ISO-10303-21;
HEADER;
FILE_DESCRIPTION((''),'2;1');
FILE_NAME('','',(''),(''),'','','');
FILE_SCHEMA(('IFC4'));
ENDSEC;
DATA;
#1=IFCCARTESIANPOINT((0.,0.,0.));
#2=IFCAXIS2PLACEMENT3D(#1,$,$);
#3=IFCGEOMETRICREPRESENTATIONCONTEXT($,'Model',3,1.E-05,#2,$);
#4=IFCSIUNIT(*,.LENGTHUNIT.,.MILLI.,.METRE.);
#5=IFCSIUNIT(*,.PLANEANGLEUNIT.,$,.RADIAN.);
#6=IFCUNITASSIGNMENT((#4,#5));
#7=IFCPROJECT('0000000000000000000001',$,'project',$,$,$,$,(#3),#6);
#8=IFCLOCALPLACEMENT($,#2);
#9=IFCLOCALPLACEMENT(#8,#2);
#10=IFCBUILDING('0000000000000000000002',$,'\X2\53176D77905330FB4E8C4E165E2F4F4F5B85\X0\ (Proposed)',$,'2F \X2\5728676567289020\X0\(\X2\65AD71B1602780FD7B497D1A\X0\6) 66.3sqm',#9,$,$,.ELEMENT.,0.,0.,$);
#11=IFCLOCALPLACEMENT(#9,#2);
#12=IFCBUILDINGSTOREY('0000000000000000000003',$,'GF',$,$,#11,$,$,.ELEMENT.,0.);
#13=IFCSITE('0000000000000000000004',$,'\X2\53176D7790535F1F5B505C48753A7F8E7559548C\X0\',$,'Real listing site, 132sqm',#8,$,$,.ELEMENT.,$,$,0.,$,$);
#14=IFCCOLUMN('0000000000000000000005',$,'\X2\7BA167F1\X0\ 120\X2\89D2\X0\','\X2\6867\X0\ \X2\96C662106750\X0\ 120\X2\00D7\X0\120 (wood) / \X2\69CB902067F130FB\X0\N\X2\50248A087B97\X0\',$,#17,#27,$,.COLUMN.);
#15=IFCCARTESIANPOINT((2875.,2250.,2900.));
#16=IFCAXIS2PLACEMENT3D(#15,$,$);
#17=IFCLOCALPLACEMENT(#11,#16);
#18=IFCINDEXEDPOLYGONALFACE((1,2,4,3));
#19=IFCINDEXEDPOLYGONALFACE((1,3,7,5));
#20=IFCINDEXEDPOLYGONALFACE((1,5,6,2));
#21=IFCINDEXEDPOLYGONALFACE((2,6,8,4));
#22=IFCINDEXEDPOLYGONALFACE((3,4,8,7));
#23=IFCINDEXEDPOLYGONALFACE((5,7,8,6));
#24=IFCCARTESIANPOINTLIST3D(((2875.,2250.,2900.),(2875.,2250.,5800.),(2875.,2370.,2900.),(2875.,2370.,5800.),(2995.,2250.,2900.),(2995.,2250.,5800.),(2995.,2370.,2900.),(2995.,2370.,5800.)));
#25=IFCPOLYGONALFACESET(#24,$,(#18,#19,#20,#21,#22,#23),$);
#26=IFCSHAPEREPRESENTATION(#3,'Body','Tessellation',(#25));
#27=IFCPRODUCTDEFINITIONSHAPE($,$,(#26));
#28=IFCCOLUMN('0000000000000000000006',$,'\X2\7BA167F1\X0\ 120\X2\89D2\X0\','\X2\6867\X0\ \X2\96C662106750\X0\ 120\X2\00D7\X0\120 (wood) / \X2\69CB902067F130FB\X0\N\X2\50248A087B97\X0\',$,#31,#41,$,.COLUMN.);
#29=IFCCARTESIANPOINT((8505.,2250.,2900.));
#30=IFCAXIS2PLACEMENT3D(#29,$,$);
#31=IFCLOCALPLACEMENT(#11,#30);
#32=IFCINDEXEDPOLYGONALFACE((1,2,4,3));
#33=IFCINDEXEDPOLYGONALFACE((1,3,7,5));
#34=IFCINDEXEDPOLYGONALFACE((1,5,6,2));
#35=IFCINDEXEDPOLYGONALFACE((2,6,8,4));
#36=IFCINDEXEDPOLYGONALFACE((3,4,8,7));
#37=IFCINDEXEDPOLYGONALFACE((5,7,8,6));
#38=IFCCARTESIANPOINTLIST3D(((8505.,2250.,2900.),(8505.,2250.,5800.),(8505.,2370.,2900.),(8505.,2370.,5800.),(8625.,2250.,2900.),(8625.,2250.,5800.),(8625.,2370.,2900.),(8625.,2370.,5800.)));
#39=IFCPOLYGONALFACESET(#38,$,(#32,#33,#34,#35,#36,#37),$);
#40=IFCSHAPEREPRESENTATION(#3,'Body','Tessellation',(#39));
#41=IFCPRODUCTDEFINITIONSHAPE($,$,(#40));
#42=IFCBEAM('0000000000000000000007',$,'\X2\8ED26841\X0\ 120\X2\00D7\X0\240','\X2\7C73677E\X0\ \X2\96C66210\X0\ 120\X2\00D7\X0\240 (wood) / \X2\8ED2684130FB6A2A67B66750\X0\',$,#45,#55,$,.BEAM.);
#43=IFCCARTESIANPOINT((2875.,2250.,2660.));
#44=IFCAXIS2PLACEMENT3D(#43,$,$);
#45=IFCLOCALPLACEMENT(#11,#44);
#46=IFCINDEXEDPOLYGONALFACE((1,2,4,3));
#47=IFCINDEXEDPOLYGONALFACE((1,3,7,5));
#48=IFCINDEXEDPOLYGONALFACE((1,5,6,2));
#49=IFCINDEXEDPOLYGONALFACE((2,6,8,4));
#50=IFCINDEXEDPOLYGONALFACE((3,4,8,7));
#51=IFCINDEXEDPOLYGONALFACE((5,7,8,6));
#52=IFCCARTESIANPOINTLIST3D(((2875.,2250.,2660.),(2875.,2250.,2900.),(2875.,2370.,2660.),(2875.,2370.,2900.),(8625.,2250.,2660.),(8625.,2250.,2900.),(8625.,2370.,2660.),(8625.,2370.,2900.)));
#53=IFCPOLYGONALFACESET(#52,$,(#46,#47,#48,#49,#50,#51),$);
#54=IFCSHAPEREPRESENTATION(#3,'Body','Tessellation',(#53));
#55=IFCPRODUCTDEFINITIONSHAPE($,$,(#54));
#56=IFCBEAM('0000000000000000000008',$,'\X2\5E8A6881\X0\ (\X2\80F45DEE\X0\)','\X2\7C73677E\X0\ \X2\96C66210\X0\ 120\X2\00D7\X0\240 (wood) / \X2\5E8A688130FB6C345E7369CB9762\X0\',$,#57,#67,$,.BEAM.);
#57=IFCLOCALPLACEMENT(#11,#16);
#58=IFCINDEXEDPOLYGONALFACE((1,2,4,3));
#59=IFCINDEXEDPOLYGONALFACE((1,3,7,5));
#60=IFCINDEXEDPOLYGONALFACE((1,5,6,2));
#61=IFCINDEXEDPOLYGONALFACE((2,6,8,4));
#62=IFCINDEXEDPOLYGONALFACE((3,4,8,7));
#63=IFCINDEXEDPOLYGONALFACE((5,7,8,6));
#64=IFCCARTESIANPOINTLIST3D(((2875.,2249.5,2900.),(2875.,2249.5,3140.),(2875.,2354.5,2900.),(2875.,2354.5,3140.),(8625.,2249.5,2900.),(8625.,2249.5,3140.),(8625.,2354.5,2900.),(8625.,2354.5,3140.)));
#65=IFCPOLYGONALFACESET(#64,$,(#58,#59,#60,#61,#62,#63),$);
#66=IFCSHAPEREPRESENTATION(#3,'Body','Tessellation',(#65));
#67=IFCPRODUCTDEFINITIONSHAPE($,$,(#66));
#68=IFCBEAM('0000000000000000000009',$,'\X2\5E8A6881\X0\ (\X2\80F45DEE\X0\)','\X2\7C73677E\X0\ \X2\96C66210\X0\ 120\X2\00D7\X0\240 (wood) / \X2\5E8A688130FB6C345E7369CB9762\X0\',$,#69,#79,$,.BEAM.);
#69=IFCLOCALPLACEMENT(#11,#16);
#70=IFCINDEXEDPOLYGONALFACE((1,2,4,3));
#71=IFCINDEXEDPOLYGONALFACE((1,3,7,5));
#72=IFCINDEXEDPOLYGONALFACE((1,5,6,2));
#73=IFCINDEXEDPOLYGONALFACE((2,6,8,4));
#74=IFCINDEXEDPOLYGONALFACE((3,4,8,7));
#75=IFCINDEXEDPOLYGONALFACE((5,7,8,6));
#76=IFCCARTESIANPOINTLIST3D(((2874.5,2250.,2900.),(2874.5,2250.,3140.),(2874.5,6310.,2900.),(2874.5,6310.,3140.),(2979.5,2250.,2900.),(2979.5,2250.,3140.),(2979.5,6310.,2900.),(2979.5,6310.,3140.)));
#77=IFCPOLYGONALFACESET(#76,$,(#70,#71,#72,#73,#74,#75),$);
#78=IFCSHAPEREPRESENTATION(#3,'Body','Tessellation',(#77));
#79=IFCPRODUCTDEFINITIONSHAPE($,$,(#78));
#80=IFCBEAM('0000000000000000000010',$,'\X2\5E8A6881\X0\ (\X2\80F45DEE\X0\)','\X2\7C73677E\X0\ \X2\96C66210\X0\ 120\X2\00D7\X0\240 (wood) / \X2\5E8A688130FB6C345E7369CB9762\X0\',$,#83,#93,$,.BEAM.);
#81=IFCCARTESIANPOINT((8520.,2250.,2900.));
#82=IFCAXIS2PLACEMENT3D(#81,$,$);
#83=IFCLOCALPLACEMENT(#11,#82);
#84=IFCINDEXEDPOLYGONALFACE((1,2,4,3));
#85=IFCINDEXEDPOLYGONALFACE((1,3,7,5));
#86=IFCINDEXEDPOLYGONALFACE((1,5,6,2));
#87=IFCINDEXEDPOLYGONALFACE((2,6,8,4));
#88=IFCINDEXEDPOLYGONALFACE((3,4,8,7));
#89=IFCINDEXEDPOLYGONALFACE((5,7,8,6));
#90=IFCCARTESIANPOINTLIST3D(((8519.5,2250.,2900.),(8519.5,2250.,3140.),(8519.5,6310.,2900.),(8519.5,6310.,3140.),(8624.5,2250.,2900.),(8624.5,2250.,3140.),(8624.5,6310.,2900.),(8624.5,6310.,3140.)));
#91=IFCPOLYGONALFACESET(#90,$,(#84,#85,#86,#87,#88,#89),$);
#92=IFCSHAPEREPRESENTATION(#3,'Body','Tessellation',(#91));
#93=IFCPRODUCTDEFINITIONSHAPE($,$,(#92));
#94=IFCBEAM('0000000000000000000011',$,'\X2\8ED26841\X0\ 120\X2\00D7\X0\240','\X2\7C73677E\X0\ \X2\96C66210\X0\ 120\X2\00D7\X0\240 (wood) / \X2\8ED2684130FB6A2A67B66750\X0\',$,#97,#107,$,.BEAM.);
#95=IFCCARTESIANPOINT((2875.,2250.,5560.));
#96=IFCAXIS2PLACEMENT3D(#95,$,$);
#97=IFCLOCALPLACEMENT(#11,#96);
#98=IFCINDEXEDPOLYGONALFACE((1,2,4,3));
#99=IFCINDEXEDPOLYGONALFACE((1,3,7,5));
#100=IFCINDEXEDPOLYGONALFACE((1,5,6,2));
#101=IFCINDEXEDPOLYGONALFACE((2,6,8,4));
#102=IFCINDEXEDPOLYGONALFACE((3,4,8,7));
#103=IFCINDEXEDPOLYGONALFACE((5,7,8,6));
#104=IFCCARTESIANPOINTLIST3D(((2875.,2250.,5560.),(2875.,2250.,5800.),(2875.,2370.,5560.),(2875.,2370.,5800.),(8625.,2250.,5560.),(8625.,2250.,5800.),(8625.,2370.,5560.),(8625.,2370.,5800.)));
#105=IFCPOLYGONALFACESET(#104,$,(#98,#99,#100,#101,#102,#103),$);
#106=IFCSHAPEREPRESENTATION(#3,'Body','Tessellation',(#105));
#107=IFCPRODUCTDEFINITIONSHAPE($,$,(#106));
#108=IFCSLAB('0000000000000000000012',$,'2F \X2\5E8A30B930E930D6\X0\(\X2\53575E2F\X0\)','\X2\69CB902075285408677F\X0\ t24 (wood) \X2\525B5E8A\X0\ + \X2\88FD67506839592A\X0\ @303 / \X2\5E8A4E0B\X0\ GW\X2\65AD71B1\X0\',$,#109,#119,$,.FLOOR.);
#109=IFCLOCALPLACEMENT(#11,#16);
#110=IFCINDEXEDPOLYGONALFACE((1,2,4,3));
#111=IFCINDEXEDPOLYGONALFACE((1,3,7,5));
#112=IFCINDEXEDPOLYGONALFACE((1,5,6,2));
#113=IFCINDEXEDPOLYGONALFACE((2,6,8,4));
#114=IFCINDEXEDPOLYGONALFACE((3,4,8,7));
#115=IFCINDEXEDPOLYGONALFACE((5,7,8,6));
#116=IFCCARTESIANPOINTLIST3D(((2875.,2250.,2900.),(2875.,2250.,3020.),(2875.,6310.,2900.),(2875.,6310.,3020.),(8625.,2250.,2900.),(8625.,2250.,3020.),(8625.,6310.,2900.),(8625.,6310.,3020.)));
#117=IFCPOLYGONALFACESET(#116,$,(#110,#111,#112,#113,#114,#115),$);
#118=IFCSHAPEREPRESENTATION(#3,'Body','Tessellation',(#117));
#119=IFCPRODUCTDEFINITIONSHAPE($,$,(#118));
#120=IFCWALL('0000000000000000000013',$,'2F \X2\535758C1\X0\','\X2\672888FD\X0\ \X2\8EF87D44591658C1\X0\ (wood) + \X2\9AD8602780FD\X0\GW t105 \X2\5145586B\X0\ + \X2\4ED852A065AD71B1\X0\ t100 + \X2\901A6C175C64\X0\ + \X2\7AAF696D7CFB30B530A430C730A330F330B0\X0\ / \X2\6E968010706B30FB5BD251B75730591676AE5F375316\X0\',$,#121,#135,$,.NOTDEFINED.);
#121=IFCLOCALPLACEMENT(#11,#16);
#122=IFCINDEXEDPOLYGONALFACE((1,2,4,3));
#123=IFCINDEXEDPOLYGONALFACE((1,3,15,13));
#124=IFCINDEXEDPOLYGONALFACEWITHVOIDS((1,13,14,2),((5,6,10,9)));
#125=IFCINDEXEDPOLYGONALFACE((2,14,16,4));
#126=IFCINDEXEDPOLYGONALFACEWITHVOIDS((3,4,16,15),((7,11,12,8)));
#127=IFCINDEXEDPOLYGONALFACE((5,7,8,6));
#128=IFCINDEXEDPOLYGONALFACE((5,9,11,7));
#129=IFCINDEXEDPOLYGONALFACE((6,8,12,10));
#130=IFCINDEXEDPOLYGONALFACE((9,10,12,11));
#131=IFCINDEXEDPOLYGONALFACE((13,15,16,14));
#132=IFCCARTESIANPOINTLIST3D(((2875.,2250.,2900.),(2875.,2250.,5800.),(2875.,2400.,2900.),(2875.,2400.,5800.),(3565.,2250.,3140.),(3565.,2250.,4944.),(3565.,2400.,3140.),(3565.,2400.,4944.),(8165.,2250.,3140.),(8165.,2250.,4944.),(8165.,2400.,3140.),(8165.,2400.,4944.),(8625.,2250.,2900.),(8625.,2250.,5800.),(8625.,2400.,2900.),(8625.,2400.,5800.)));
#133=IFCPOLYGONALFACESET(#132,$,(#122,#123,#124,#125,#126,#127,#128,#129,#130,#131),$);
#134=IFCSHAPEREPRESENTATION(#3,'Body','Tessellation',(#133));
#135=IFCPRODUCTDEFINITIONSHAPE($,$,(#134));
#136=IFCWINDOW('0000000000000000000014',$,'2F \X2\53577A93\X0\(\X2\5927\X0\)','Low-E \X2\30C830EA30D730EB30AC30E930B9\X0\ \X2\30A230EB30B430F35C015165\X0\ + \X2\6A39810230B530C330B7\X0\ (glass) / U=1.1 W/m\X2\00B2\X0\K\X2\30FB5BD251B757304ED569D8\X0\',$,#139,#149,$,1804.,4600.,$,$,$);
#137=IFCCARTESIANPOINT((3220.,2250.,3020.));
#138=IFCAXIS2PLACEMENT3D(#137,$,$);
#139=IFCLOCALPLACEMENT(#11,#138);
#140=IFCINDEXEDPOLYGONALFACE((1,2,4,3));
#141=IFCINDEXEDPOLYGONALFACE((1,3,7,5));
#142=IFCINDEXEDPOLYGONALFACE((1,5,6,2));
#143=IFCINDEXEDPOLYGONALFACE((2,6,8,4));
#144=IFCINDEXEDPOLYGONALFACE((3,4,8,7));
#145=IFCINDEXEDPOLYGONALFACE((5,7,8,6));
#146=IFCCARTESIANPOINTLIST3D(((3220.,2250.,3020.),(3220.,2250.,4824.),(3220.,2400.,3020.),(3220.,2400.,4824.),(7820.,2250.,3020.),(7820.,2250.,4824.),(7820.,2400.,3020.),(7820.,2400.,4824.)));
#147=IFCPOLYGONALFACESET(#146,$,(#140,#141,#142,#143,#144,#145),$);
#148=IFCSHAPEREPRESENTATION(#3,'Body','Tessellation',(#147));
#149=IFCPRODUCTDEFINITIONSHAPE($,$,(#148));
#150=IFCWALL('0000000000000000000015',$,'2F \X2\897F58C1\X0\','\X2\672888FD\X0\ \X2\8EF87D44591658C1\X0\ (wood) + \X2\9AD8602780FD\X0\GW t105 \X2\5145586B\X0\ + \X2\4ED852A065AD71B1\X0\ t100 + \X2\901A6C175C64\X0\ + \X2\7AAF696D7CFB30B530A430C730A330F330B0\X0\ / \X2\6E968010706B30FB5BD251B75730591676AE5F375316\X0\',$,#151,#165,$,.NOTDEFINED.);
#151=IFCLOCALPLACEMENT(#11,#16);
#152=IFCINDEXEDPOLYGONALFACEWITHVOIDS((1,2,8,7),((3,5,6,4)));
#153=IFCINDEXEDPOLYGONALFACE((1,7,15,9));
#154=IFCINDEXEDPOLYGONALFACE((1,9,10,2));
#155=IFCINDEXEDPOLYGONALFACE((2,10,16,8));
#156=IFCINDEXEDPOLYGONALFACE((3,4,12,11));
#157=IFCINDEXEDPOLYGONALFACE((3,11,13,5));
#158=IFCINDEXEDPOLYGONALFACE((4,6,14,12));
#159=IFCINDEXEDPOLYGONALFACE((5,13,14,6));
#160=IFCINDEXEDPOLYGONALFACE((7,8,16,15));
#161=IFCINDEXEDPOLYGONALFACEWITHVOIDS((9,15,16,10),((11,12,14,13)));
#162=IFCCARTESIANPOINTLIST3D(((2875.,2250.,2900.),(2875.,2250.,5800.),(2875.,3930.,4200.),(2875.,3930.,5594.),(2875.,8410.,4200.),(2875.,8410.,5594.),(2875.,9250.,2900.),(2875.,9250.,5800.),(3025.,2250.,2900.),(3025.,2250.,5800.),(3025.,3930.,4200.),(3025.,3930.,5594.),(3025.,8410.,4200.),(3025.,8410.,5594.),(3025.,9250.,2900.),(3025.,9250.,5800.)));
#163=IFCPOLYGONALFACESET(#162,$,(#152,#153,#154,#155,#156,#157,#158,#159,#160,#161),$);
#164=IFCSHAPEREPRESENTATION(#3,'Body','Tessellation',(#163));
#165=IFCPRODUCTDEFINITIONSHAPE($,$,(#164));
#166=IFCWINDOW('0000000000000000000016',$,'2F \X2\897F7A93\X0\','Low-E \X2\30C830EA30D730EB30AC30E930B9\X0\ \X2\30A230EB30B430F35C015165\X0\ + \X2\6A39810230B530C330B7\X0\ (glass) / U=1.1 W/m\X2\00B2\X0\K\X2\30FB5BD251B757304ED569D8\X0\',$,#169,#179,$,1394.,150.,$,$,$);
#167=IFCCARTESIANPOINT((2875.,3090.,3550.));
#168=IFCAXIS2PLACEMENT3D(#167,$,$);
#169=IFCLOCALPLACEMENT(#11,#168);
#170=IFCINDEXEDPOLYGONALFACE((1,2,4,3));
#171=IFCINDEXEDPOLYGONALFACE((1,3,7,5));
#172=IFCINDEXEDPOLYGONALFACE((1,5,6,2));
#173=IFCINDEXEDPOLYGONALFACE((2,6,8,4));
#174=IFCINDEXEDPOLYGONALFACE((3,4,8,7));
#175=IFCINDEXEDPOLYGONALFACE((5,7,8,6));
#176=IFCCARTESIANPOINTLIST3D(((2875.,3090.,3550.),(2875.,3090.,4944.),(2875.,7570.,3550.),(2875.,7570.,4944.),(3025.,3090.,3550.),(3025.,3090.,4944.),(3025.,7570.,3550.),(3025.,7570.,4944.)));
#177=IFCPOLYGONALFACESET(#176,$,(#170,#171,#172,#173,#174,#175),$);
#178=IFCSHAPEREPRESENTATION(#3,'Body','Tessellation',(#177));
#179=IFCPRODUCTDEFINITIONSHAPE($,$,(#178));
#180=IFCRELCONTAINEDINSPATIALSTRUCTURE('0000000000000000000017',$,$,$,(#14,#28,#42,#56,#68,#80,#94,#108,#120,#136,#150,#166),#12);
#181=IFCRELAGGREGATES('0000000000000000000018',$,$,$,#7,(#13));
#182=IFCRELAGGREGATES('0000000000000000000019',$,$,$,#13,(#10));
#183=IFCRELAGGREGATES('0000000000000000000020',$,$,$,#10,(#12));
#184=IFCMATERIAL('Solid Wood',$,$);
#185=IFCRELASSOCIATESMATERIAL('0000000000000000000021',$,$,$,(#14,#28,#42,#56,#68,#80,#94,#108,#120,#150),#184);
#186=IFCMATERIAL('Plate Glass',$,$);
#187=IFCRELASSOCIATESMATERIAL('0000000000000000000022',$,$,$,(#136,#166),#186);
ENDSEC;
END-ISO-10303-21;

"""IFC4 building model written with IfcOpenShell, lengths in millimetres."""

from ifc_helpers import new_model, si_unit, frame, frame_2d, origin, place, context, project, spatial, rectangle, extrude, material, element, fill, save


model = new_model("IFC4")

# Units and contexts
model_context = context("Model", 3, precision=1e-05, world=origin())
ifc_project = project(units=[si_unit("LENGTHUNIT", "METRE", prefix="MILLI"), si_unit("PLANEANGLEUNIT", "RADIAN")], contexts=[model_context])

# Site, building, storey
site_placement = place(None, origin())
site = spatial("IfcSite", under=ifc_project, at=site_placement, Name="北海道弟子屈町美留和", ObjectType="Real listing site, 132sqm", CompositionType="ELEMENT", RefElevation=0.0)
building_placement = place(site_placement, origin())
building = spatial("IfcBuilding", under=site, at=building_placement, Name="北海道・二世帯住宅 (Proposed)", ObjectType="2F 在来木造(断熱性能等級6) 66.3sqm", CompositionType="ELEMENT", ElevationOfRefHeight=0.0, ElevationOfTerrain=0.0)
storey_placement = place(building_placement, origin())
storey = spatial("IfcBuildingStorey", under=building, at=storey_placement, Name="GF", CompositionType="ELEMENT", Elevation=0.0)

# Columns
ifc_material_1 = material(Name="Solid Wood")
column_1_placement = place(storey_placement, frame((2875.0, 2250.0, 2900.0)))
element("IfcColumn", 1, at=column_1_placement, inside=storey, material=ifc_material_1, Name="管柱 120角", Description="桧 集成材 120×120 (wood) / 構造柱・N値計算", PredefinedType="COLUMN", context=model_context, shape_type="SweptSolid", body=[
    extrude(rectangle(XDim=120.0, YDim=120.0, at=frame_2d((60.0, 60.0))), frame((2875.0, 2250.0, 2900.0)), (0.0, 0.0, 1.0), 2900.0),
])
column_2_placement = place(storey_placement, frame((8505.0, 2250.0, 2900.0)))
element("IfcColumn", 2, at=column_2_placement, inside=storey, material=ifc_material_1, Name="管柱 120角", Description="桧 集成材 120×120 (wood) / 構造柱・N値計算", PredefinedType="COLUMN", context=model_context, shape_type="SweptSolid", body=[
    extrude(rectangle(XDim=120.0, YDim=120.0, at=frame_2d((60.0, 60.0))), frame((8505.0, 2250.0, 2900.0)), (0.0, 0.0, 1.0), 2900.0),
])

# Beams
beam_1_placement = place(storey_placement, frame((2875.0, 2250.0, 2660.0)))
element("IfcBeam", 3, at=beam_1_placement, inside=storey, material=ifc_material_1, Name="軒桁 120×240", Description="米松 集成 120×240 (wood) / 軒桁・横架材", PredefinedType="BEAM", context=model_context, shape_type="SweptSolid", body=[
    extrude(rectangle(XDim=5750.0, YDim=120.0, at=frame_2d((2875.0, 60.0))), frame((2875.0, 2250.0, 2660.0)), (0.0, 0.0, 1.0), 240.0),
])
beam_2_placement = place(storey_placement, frame((2875.0, 2250.0, 2900.0)))
element("IfcBeam", 4, at=beam_2_placement, inside=storey, material=ifc_material_1, Name="床梁 (胴差)", Description="米松 集成 120×240 (wood) / 床梁・水平構面", PredefinedType="BEAM", context=model_context, shape_type="SweptSolid", body=[
    extrude(rectangle(XDim=5750.0, YDim=105.0, at=frame_2d((2875.0, 52.0))), frame((2875.0, 2250.0, 2900.0)), (0.0, 0.0, 1.0), 240.0),
])
beam_3_placement = place(storey_placement, frame((2875.0, 2250.0, 2900.0)))
element("IfcBeam", 5, at=beam_3_placement, inside=storey, material=ifc_material_1, Name="床梁 (胴差)", Description="米松 集成 120×240 (wood) / 床梁・水平構面", PredefinedType="BEAM", context=model_context, shape_type="SweptSolid", body=[
    extrude(rectangle(XDim=105.0, YDim=4060.0, at=frame_2d((52.0, 2030.0))), frame((2875.0, 2250.0, 2900.0)), (0.0, 0.0, 1.0), 240.0),
])
beam_4_placement = place(storey_placement, frame((8520.0, 2250.0, 2900.0)))
element("IfcBeam", 6, at=beam_4_placement, inside=storey, material=ifc_material_1, Name="床梁 (胴差)", Description="米松 集成 120×240 (wood) / 床梁・水平構面", PredefinedType="BEAM", context=model_context, shape_type="SweptSolid", body=[
    extrude(rectangle(XDim=105.0, YDim=4060.0, at=frame_2d((52.0, 2030.0))), frame((8520.0, 2250.0, 2900.0)), (0.0, 0.0, 1.0), 240.0),
])
beam_5_placement = place(storey_placement, frame((2875.0, 2250.0, 5560.0)))
element("IfcBeam", 7, at=beam_5_placement, inside=storey, material=ifc_material_1, Name="軒桁 120×240", Description="米松 集成 120×240 (wood) / 軒桁・横架材", PredefinedType="BEAM", context=model_context, shape_type="SweptSolid", body=[
    extrude(rectangle(XDim=5750.0, YDim=120.0, at=frame_2d((2875.0, 60.0))), frame((2875.0, 2250.0, 5560.0)), (0.0, 0.0, 1.0), 240.0),
])

# Slab
slab_placement = place(storey_placement, frame((2875.0, 2250.0, 2900.0)))
element("IfcSlab", 8, at=slab_placement, inside=storey, material=ifc_material_1, Name="2F 床スラブ(南帯)", Description="構造用合板 t24 (wood) 剛床 + 製材根太 @303 / 床下 GW断熱", PredefinedType="FLOOR", context=model_context, shape_type="SweptSolid", body=[
    extrude(rectangle(XDim=5750.0, YDim=4060.0, at=frame_2d((2875.0, 2030.0))), frame((2875.0, 2250.0, 2900.0)), (0.0, 0.0, 1.0), 120.0),
])

# Walls, openings, windows
wall_1_placement = place(storey_placement, frame((2875.0, 2250.0, 2900.0)))
wall_1 = element("IfcWall", 9, at=wall_1_placement, inside=storey, material=ifc_material_1, Name="2F 南壁", Description="木製 軸組外壁 (wood) + 高性能GW t105 充填 + 付加断熱 t100 + 通気層 + 窯業系サイディング / 準耐火・寒冷地外皮強化", PredefinedType="NOTDEFINED", context=model_context, shape_type="SweptSolid", body=[
    extrude(rectangle(XDim=5750.0, YDim=150.0, at=frame_2d((2875.0, 75.0))), frame((2875.0, 2250.0, 2900.0)), (0.0, 0.0, 1.0), 2900.0),
])
opening_1_placement = place(storey_placement, frame((3220.0, 2250.0, 3020.0)))
opening_1 = element("IfcOpeningElement", 10, at=opening_1_placement, cuts=wall_1, PredefinedType="NOTDEFINED", context=model_context, shape_type="SweptSolid", body=[
    extrude(rectangle(XDim=4600.0, YDim=150.0, at=frame_2d((2300.0, 75.0))), frame((3220.0, 2250.0, 3020.0)), (0.0, 0.0, 1.0), 1804.0),
])
ifc_material_2 = material(Name="Plate Glass")
window_1_placement = place(storey_placement, frame((3220.0, 2250.0, 3020.0)))
window_1 = element("IfcWindow", 11, at=window_1_placement, inside=storey, material=ifc_material_2, Name="2F 南窓(大)", Description="Low-E トリプルガラス アルゴン封入 + 樹脂サッシ (glass) / U=1.1 W/m²K・寒冷地仕様", OverallHeight=1804.0, OverallWidth=4600.0, context=model_context, shape_type="SweptSolid", body=[
    extrude(rectangle(XDim=4600.0, YDim=150.0, at=frame_2d((2300.0, 75.0))), frame((3220.0, 2250.0, 3020.0)), (0.0, 0.0, 1.0), 1804.0),
])
fill(opening_1, window_1)
wall_2_placement = place(storey_placement, frame((2875.0, 2250.0, 2900.0)))
wall_2 = element("IfcWall", 12, at=wall_2_placement, inside=storey, material=ifc_material_1, Name="2F 西壁", Description="木製 軸組外壁 (wood) + 高性能GW t105 充填 + 付加断熱 t100 + 通気層 + 窯業系サイディング / 準耐火・寒冷地外皮強化", PredefinedType="NOTDEFINED", context=model_context, shape_type="SweptSolid", body=[
    extrude(rectangle(XDim=150.0, YDim=7000.0, at=frame_2d((75.0, 3500.0))), frame((2875.0, 2250.0, 2900.0)), (0.0, 0.0, 1.0), 2900.0),
])
opening_2_placement = place(storey_placement, frame((2875.0, 3090.0, 3550.0)))
opening_2 = element("IfcOpeningElement", 13, at=opening_2_placement, cuts=wall_2, PredefinedType="NOTDEFINED", context=model_context, shape_type="SweptSolid", body=[
    extrude(rectangle(XDim=150.0, YDim=4480.0, at=frame_2d((75.0, 2240.0))), frame((2875.0, 3090.0, 3550.0)), (0.0, 0.0, 1.0), 1394.0),
])
window_2_placement = place(storey_placement, frame((2875.0, 3090.0, 3550.0)))
window_2 = element("IfcWindow", 14, at=window_2_placement, inside=storey, material=ifc_material_2, Name="2F 西窓", Description="Low-E トリプルガラス アルゴン封入 + 樹脂サッシ (glass) / U=1.1 W/m²K・寒冷地仕様", OverallHeight=1394.0, OverallWidth=150.0, context=model_context, shape_type="SweptSolid", body=[
    extrude(rectangle(XDim=150.0, YDim=4480.0, at=frame_2d((75.0, 2240.0))), frame((2875.0, 3090.0, 3550.0)), (0.0, 0.0, 1.0), 1394.0),
])
fill(opening_2, window_2)

save(model, "model.ifc")
